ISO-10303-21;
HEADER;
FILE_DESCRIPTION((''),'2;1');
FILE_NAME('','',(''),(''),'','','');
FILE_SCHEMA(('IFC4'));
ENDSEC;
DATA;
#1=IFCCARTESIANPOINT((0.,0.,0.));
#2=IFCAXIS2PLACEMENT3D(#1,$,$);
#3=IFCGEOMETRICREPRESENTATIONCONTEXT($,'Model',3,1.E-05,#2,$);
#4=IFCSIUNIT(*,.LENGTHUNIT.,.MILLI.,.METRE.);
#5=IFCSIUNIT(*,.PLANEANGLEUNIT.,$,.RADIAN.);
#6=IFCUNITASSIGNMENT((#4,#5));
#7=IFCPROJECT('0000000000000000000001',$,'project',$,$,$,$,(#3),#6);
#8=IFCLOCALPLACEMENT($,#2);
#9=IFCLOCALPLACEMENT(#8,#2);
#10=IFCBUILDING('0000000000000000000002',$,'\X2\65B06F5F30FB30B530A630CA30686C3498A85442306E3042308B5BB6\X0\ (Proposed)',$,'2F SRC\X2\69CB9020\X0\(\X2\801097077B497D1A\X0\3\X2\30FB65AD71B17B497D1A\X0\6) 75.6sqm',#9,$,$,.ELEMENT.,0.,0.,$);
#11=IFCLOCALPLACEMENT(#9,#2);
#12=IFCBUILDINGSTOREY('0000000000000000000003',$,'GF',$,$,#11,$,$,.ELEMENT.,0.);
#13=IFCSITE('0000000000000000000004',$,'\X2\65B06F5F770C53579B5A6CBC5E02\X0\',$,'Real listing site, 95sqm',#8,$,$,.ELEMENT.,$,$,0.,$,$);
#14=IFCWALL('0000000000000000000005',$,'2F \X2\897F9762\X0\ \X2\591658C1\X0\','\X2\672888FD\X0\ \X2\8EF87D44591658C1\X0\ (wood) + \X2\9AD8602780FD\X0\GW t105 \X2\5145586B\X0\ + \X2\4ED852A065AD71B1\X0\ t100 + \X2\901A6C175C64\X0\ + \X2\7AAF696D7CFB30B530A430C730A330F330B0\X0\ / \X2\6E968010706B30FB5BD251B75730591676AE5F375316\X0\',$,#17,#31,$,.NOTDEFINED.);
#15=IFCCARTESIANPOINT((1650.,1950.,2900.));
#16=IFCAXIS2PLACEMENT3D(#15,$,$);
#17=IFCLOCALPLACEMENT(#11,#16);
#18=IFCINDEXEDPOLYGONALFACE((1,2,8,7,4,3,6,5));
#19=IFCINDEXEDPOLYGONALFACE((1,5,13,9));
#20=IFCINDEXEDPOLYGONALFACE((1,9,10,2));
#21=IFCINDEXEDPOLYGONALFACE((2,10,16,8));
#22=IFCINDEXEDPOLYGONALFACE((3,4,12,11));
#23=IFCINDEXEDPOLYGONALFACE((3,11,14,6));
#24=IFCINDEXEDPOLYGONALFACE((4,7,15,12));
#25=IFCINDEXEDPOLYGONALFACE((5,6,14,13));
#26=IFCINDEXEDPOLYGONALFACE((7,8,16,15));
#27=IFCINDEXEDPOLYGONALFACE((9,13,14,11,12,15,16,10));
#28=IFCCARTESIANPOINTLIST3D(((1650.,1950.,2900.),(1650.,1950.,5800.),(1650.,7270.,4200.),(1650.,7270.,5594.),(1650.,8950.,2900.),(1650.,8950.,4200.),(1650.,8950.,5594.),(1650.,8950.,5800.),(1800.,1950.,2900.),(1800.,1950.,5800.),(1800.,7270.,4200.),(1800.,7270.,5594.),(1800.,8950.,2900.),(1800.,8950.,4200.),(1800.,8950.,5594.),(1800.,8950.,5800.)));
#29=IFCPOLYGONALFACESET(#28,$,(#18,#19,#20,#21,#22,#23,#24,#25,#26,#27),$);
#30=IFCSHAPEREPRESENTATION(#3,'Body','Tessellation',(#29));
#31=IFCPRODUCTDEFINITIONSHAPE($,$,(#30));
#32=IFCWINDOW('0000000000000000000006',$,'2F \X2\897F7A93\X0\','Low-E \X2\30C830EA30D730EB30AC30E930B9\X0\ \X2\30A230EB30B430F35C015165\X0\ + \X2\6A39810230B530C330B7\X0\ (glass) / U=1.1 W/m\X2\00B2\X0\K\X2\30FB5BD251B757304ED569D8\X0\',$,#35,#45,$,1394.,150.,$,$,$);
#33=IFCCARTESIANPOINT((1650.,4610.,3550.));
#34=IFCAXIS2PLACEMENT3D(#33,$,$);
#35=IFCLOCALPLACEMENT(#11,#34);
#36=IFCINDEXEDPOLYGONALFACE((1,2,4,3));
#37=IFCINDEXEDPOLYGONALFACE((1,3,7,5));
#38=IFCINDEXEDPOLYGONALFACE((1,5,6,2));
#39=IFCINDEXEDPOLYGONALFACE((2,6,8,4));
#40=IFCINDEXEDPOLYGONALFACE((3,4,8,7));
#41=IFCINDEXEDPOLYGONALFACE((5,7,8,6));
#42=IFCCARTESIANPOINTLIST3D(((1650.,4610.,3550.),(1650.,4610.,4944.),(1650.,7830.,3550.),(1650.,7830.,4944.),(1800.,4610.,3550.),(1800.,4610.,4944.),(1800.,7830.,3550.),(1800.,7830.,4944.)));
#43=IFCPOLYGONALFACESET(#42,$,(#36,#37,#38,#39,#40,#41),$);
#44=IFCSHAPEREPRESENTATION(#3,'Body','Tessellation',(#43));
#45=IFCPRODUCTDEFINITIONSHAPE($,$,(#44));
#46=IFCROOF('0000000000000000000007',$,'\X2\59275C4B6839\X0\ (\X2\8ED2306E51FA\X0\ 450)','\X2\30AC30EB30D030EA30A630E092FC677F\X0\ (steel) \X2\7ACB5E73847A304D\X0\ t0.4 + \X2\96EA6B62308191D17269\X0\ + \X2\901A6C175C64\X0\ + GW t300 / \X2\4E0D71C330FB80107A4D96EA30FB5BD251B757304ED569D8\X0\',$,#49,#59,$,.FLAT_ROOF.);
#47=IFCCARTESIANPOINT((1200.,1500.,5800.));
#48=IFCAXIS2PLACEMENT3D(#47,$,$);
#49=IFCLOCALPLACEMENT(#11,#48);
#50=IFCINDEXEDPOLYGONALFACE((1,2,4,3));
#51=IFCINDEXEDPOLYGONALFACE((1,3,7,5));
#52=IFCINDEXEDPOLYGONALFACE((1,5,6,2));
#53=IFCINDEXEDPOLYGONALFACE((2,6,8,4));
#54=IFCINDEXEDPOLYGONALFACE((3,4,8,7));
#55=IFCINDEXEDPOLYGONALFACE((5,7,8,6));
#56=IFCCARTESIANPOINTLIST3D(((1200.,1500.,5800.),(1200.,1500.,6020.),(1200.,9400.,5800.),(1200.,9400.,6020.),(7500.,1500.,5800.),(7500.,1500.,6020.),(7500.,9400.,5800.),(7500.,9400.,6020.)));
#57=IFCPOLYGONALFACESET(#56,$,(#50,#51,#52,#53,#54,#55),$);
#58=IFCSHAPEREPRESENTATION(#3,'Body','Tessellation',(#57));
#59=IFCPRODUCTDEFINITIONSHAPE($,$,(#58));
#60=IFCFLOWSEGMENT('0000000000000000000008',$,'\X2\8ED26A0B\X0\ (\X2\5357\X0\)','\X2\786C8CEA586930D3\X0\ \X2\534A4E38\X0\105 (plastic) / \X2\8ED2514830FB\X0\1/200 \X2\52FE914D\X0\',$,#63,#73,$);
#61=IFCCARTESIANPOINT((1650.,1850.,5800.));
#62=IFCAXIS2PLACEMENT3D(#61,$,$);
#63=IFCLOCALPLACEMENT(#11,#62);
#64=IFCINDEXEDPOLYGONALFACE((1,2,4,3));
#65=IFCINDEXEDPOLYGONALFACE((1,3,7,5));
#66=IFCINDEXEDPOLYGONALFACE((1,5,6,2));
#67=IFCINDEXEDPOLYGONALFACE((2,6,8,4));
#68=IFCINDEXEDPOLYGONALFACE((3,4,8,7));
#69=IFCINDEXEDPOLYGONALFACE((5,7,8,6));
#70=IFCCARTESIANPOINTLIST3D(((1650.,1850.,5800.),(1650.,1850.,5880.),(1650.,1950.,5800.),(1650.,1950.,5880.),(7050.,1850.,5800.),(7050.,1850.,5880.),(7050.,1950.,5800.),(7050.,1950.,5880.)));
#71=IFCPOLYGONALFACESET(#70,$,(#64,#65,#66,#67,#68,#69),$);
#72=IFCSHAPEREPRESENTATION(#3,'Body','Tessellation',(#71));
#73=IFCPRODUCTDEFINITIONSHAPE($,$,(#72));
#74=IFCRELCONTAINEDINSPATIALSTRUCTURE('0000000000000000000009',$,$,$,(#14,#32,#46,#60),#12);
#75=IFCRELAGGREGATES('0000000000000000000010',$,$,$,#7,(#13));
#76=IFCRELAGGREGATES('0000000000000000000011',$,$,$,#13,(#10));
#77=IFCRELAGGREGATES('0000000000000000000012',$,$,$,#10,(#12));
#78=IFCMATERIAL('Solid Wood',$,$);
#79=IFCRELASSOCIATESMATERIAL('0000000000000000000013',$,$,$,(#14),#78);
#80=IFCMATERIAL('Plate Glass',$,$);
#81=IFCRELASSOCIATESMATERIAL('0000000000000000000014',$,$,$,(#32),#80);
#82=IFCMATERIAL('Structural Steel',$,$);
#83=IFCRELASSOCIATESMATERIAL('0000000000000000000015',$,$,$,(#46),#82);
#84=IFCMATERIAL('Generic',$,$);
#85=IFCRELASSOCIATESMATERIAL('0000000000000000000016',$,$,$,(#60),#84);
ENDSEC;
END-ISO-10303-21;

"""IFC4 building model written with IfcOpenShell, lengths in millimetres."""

from ifc_helpers import new_model, si_unit, frame, frame_2d, origin, place, context, project, spatial, rectangle, extrude, material, element, fill, save


model = new_model("IFC4")

# Units and contexts
model_context = context("Model", 3, precision=1e-05, world=origin())
ifc_project = project(units=[si_unit("LENGTHUNIT", "METRE", prefix="MILLI"), si_unit("PLANEANGLEUNIT", "RADIAN")], contexts=[model_context])

# Site, building, storey
site_placement = place(None, origin())
site = spatial("IfcSite", under=ifc_project, at=site_placement, Name="新潟県南魚沼市", ObjectType="Real listing site, 95sqm", CompositionType="ELEMENT", RefElevation=0.0)
building_placement = place(site_placement, origin())
building = spatial("IfcBuilding", under=site, at=building_placement, Name="新潟・サウナと水風呂のある家 (Proposed)", ObjectType="2F SRC構造(耐震等級3・断熱等級6) 75.6sqm", CompositionType="ELEMENT", ElevationOfRefHeight=0.0, ElevationOfTerrain=0.0)
storey_placement = place(building_placement, origin())
storey = spatial("IfcBuildingStorey", under=building, at=storey_placement, Name="GF", CompositionType="ELEMENT", Elevation=0.0)

# Shared definitions
ifc_material_1 = material(Name="Solid Wood")

# Shared definitions
ifc_material_2 = material(Name="Plate Glass")

# Wall, opening, window
wall_1_placement = place(storey_placement, frame((1650.0, 1950.0, 2900.0)))
wall_1 = element("IfcWall", 1, at=wall_1_placement, inside=storey, material=ifc_material_1, Name="2F 西面 外壁", Description="木製 軸組外壁 (wood) + 高性能GW t105 充填 + 付加断熱 t100 + 通気層 + 窯業系サイディング / 準耐火・寒冷地外皮強化", PredefinedType="NOTDEFINED", context=model_context, shape_type="SweptSolid", body=[
    extrude(rectangle(XDim=150.0, YDim=7000.0, at=frame_2d((75.0, 3500.0))), frame((1650.0, 1950.0, 2900.0)), (0.0, 0.0, 1.0), 2900.0),
])
opening_1_placement = place(storey_placement, frame((1650.0, 4610.0, 3550.0)))
opening_1 = element("IfcOpeningElement", 2, at=opening_1_placement, cuts=wall_1, PredefinedType="NOTDEFINED", context=model_context, shape_type="SweptSolid", body=[
    extrude(rectangle(XDim=150.0, YDim=3220.0, at=frame_2d((75.0, 1610.0))), frame((1650.0, 4610.0, 3550.0)), (0.0, 0.0, 1.0), 1394.0),
])
window_1_placement = place(storey_placement, frame((1650.0, 4610.0, 3550.0)))
window_1 = element("IfcWindow", 3, at=window_1_placement, inside=storey, material=ifc_material_2, Name="2F 西窓", Description="Low-E トリプルガラス アルゴン封入 + 樹脂サッシ (glass) / U=1.1 W/m²K・寒冷地仕様", OverallHeight=1394.0, OverallWidth=150.0, context=model_context, shape_type="SweptSolid", body=[
    extrude(rectangle(XDim=150.0, YDim=3220.0, at=frame_2d((75.0, 1610.0))), frame((1650.0, 4610.0, 3550.0)), (0.0, 0.0, 1.0), 1394.0),
])
fill(opening_1, window_1)

# Roof
ifc_material_3 = material(Name="Structural Steel")
roof_placement = place(storey_placement, frame((1200.0, 1500.0, 5800.0)))
element("IfcRoof", 4, at=roof_placement, inside=storey, material=ifc_material_3, Name="大屋根 (軒の出 450)", Description="ガルバリウム鋼板 (steel) 立平葺き t0.4 + 雪止め金物 + 通気層 + GW t300 / 不燃・耐積雪・寒冷地仕様", PredefinedType="FLAT_ROOF", context=model_context, shape_type="SweptSolid", body=[
    extrude(rectangle(XDim=6300.0, YDim=7900.0, at=frame_2d((3150.0, 3950.0))), frame((1200.0, 1500.0, 5800.0)), (0.0, 0.0, 1.0), 220.0),
])

# Flow segment
ifc_material_4 = material(Name="Generic")
flow_segment_placement = place(storey_placement, frame((1650.0, 1850.0, 5800.0)))
element("IfcFlowSegment", 5, at=flow_segment_placement, inside=storey, material=ifc_material_4, Name="軒樋 (南)", Description="硬質塩ビ 半丸105 (plastic) / 軒先・1/200 勾配", context=model_context, shape_type="SweptSolid", body=[
    extrude(rectangle(XDim=5400.0, YDim=100.0, at=frame_2d((2700.0, 50.0))), frame((1650.0, 1850.0, 5800.0)), (0.0, 0.0, 1.0), 80.0),
])

save(model, "model.ifc")
